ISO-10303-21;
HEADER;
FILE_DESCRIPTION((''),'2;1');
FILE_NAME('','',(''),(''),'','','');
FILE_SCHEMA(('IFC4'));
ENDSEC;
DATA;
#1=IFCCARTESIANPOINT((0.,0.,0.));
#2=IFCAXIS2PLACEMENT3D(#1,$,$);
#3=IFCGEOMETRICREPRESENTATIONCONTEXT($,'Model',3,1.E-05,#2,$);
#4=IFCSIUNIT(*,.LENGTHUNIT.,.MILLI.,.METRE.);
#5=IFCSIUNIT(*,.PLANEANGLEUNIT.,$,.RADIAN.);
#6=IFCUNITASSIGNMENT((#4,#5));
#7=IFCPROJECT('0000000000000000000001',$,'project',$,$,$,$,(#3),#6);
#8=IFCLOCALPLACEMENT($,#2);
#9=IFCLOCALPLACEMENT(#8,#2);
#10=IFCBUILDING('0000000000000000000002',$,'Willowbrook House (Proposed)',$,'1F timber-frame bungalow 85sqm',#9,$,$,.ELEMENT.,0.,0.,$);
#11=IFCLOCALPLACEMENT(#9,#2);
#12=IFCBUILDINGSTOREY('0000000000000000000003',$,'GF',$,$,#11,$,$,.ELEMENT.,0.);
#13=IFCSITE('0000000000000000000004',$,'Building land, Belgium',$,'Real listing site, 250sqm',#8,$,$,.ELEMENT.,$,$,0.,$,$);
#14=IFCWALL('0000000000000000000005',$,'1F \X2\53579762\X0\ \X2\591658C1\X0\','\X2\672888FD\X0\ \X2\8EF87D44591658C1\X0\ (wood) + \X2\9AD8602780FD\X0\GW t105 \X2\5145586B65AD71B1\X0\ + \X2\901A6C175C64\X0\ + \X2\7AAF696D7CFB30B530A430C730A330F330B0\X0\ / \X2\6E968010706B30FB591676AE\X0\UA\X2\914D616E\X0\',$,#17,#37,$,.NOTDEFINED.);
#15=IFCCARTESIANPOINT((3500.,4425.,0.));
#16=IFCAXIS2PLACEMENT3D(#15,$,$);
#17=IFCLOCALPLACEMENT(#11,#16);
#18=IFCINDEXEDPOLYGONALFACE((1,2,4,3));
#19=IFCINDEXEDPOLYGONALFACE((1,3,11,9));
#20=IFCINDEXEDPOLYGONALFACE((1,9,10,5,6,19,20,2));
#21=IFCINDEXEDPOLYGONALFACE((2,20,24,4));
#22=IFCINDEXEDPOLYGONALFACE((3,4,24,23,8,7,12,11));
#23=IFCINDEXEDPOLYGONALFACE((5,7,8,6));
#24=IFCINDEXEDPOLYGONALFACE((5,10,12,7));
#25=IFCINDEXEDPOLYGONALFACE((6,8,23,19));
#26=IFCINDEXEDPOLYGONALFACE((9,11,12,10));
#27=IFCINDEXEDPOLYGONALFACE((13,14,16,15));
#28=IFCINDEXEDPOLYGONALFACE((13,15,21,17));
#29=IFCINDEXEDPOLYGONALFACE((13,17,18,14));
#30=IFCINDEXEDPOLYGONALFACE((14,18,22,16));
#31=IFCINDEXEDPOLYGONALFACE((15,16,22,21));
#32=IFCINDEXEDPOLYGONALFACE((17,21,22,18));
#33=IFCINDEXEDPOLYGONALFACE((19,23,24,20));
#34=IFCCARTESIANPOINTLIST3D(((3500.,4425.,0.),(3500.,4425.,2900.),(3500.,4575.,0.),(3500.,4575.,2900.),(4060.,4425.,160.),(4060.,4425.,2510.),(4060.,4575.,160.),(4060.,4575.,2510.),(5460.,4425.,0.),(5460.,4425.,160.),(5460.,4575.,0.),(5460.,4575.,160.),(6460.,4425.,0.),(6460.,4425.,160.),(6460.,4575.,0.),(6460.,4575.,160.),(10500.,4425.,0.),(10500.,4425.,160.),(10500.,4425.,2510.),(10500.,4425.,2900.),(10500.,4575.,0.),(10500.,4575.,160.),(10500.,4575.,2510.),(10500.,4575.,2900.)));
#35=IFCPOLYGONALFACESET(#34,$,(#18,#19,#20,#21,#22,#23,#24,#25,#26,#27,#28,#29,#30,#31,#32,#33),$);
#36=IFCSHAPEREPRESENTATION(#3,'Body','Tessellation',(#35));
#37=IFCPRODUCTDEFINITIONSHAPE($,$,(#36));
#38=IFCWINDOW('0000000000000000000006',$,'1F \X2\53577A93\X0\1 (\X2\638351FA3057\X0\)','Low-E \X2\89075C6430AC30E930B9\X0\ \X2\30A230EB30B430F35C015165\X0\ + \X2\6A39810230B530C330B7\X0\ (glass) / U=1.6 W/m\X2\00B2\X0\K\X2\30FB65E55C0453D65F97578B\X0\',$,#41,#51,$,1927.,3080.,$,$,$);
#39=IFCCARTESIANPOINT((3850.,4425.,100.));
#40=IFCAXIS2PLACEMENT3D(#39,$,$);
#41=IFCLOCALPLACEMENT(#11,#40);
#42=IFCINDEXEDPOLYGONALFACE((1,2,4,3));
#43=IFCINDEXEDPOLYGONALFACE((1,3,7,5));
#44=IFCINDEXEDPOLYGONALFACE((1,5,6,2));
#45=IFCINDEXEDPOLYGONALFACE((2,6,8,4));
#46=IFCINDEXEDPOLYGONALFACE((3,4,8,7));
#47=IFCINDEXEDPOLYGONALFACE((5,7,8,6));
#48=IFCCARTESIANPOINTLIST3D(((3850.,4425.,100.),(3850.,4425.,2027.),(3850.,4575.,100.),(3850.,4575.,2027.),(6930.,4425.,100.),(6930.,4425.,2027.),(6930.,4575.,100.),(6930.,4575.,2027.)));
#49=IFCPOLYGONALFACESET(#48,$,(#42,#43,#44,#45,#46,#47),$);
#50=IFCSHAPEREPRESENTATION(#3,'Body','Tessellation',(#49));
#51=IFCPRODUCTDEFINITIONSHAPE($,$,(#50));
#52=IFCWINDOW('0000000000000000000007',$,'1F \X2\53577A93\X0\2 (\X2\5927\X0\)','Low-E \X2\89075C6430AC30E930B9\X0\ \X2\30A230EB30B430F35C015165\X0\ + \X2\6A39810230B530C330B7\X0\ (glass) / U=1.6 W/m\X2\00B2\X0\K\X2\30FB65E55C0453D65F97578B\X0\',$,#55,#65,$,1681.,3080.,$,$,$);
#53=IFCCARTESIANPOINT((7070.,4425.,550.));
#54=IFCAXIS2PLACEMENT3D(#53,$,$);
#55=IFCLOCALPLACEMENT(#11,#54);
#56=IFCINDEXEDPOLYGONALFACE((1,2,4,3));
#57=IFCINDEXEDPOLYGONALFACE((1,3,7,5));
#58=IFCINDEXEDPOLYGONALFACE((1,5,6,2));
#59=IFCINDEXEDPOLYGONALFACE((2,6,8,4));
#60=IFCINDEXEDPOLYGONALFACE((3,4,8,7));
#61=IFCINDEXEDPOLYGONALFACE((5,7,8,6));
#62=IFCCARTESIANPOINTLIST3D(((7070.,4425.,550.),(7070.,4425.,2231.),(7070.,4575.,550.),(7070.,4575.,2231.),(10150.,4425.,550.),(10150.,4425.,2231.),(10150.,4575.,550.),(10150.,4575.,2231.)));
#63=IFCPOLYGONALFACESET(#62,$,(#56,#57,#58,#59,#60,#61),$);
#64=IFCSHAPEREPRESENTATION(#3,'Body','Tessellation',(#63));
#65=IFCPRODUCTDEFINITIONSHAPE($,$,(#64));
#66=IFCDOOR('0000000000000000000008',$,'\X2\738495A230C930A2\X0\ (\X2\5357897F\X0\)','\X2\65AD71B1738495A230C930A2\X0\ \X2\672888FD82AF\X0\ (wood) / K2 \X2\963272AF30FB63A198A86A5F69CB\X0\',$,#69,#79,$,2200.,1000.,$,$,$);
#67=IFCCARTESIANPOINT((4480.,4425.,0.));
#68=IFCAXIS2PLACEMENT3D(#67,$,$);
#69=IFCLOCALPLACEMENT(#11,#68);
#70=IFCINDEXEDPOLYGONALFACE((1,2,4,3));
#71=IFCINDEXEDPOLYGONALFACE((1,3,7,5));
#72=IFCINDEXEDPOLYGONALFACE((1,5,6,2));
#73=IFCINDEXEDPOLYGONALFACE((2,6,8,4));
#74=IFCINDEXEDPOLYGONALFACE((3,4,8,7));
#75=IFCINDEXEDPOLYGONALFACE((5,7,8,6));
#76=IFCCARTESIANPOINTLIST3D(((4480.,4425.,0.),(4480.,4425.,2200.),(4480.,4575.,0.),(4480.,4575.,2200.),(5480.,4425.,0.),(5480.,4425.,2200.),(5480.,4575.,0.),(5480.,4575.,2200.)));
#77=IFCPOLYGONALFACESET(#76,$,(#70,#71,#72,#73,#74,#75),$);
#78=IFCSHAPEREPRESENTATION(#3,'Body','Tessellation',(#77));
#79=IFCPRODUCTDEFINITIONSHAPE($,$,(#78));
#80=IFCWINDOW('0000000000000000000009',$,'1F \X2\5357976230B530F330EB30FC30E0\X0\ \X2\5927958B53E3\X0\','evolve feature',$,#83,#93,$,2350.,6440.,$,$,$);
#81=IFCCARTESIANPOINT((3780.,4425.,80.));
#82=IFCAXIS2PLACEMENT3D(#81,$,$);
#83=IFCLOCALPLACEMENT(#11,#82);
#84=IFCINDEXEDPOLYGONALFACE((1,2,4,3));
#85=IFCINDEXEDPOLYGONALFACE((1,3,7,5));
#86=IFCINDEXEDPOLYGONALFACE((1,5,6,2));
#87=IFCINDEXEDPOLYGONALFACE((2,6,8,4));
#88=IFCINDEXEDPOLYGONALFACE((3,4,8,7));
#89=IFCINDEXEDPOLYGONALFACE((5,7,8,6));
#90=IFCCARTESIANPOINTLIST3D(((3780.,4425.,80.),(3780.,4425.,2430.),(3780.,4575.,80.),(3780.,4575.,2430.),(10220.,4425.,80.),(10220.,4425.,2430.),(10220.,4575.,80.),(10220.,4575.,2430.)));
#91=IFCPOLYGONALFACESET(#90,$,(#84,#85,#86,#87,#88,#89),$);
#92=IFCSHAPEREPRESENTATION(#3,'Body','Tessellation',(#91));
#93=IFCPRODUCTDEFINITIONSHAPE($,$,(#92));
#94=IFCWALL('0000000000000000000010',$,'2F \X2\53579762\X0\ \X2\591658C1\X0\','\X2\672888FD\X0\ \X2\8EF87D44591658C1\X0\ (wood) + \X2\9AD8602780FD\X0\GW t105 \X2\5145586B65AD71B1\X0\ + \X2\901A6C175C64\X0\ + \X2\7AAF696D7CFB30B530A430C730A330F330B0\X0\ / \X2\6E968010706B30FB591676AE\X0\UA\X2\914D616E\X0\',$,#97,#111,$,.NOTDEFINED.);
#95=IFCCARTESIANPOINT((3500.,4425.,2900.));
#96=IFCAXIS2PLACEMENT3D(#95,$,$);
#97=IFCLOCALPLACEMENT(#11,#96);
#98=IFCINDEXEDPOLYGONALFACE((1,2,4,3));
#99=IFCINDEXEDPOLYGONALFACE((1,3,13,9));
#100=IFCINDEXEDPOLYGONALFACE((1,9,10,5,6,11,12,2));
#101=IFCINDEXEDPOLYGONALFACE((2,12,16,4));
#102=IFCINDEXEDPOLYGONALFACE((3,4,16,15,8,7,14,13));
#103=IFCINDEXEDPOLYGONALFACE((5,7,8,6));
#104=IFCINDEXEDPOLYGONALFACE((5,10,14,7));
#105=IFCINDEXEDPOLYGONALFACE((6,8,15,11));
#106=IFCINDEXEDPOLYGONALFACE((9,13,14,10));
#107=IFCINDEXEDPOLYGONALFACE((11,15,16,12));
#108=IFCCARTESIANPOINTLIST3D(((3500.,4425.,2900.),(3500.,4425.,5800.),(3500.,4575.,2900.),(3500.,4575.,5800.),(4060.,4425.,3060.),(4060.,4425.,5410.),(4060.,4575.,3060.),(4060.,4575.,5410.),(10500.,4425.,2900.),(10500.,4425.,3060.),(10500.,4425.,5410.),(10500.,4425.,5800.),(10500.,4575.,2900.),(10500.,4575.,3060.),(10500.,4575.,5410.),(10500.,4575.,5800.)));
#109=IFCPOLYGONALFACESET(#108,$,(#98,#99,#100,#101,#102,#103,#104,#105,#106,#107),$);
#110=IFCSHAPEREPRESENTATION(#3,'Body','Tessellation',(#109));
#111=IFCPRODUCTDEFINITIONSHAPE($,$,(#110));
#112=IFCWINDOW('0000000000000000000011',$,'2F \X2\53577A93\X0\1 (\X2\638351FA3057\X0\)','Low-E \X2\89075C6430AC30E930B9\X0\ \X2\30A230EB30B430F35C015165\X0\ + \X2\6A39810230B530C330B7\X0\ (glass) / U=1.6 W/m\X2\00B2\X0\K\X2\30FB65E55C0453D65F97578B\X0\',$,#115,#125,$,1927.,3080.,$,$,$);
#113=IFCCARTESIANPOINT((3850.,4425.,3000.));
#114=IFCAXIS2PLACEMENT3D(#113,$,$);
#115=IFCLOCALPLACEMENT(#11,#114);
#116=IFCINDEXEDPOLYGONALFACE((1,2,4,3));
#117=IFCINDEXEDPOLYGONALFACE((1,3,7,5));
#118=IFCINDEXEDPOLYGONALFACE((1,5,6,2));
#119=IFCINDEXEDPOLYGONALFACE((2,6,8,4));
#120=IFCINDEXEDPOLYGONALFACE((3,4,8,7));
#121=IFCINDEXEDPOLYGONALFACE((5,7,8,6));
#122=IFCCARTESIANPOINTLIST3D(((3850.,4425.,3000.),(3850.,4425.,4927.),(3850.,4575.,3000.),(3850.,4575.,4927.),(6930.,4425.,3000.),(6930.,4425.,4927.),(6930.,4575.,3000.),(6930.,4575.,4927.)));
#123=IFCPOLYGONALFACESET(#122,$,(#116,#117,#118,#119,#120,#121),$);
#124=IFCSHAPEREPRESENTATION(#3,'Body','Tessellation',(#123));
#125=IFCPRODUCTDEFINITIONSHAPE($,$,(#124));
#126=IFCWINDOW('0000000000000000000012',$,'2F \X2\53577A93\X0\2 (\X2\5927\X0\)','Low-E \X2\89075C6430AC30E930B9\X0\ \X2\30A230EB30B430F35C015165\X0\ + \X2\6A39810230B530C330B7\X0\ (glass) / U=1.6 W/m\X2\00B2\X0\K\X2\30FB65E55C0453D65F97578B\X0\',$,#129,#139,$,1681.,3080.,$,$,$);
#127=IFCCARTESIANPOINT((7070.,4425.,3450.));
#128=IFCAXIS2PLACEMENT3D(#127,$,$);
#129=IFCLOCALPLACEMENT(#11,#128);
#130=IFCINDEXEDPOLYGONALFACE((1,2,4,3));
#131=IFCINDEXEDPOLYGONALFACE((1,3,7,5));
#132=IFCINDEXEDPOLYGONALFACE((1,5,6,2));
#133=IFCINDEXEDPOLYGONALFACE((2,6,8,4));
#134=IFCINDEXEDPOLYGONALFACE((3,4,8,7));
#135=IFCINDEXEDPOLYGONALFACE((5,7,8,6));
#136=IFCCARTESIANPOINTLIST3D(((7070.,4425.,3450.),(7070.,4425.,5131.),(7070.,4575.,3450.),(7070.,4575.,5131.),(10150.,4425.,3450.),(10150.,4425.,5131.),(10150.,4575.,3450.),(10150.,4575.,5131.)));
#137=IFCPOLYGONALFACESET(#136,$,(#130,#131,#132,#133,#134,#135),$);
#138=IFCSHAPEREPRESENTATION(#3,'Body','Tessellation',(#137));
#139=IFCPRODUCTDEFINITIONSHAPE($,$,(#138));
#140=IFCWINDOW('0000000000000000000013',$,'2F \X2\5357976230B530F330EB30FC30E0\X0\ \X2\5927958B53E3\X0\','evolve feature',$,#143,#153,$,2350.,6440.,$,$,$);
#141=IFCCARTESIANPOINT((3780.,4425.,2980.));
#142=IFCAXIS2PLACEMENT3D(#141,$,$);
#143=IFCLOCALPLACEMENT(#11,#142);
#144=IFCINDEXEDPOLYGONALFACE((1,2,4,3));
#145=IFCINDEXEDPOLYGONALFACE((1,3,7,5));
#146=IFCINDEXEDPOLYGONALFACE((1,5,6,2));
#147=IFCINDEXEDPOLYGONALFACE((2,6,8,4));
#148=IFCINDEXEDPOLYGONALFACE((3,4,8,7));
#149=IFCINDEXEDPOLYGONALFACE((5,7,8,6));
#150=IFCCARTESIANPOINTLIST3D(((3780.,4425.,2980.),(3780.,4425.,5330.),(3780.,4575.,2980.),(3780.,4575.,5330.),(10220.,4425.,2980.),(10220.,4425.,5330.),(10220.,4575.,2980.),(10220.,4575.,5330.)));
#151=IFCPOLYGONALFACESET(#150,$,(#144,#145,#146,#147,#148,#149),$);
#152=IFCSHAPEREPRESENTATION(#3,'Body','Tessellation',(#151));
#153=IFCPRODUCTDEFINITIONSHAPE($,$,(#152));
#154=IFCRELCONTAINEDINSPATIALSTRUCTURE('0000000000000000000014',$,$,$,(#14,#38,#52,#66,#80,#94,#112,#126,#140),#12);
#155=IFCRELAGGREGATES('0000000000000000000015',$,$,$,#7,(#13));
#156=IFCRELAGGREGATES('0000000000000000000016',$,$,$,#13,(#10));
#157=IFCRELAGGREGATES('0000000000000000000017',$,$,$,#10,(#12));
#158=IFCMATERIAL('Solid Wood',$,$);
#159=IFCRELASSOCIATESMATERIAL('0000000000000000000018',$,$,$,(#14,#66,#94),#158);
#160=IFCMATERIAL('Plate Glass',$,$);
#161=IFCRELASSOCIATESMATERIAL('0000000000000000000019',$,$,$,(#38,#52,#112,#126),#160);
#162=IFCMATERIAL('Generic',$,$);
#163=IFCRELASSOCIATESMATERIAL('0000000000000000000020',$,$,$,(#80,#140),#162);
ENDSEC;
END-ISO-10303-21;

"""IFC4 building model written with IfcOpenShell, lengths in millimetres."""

from ifc_helpers import new_model, si_unit, frame, frame_2d, origin, place, context, project, spatial, rectangle, extrude, material, element, fill, save


model = new_model("IFC4")

# Units and contexts
model_context = context("Model", 3, precision=1e-05, world=origin())
ifc_project = project(units=[si_unit("LENGTHUNIT", "METRE", prefix="MILLI"), si_unit("PLANEANGLEUNIT", "RADIAN")], contexts=[model_context])

# Site, building, storey
site_placement = place(None, origin())
site = spatial("IfcSite", under=ifc_project, at=site_placement, Name="Building land, Belgium", ObjectType="Real listing site, 250sqm", CompositionType="ELEMENT", RefElevation=0.0)
building_placement = place(site_placement, origin())
building = spatial("IfcBuilding", under=site, at=building_placement, Name="Willowbrook House (Proposed)", ObjectType="1F timber-frame bungalow 85sqm", CompositionType="ELEMENT", ElevationOfRefHeight=0.0, ElevationOfTerrain=0.0)
storey_placement = place(building_placement, origin())
storey = spatial("IfcBuildingStorey", under=building, at=storey_placement, Name="GF", CompositionType="ELEMENT", Elevation=0.0)

# Shared definitions
ifc_material_1 = material(Name="Solid Wood")
ifc_material_2 = material(Name="Generic")

# Wall, openings, windows, door
wall_1_placement = place(storey_placement, frame((3500.0, 4425.0, 0.0)))
wall_1 = element("IfcWall", 1, at=wall_1_placement, inside=storey, material=ifc_material_1, Name="1F 南面 外壁", Description="木製 軸組外壁 (wood) + 高性能GW t105 充填断熱 + 通気層 + 窯業系サイディング / 準耐火・外皮UA配慮", PredefinedType="NOTDEFINED", context=model_context, shape_type="SweptSolid", body=[
    extrude(rectangle(XDim=7000.0, YDim=150.0, at=frame_2d((3500.0, 75.0))), frame((3500.0, 4425.0, 0.0)), (0.0, 0.0, 1.0), 2900.0),
])
opening_1_placement = place(storey_placement, frame((3850.0, 4425.0, 100.0)))
opening_1 = element("IfcOpeningElement", 2, at=opening_1_placement, cuts=wall_1, PredefinedType="NOTDEFINED", context=model_context, shape_type="SweptSolid", body=[
    extrude(rectangle(XDim=3080.0, YDim=150.0, at=frame_2d((1540.0, 75.0))), frame((3850.0, 4425.0, 100.0)), (0.0, 0.0, 1.0), 1927.0),
])
opening_2_placement = place(storey_placement, frame((7070.0, 4425.0, 550.0)))
opening_2 = element("IfcOpeningElement", 3, at=opening_2_placement, cuts=wall_1, PredefinedType="NOTDEFINED", context=model_context, shape_type="SweptSolid", body=[
    extrude(rectangle(XDim=3080.0, YDim=150.0, at=frame_2d((1540.0, 75.0))), frame((7070.0, 4425.0, 550.0)), (0.0, 0.0, 1.0), 1681.0),
])
opening_3_placement = place(storey_placement, frame((4480.0, 4425.0, 0.0)))
opening_3 = element("IfcOpeningElement", 4, at=opening_3_placement, cuts=wall_1, PredefinedType="NOTDEFINED", context=model_context, shape_type="SweptSolid", body=[
    extrude(rectangle(XDim=1000.0, YDim=150.0, at=frame_2d((500.0, 75.0))), frame((4480.0, 4425.0, 0.0)), (0.0, 0.0, 1.0), 2200.0),
])
opening_4_placement = place(storey_placement, frame((3780.0, 4425.0, 80.0)))
opening_4 = element("IfcOpeningElement", 5, at=opening_4_placement, cuts=wall_1, PredefinedType="NOTDEFINED", context=model_context, shape_type="SweptSolid", body=[
    extrude(rectangle(XDim=6440.0, YDim=150.0, at=frame_2d((3220.0, 75.0))), frame((3780.0, 4425.0, 80.0)), (0.0, 0.0, 1.0), 2350.0),
])
ifc_material_3 = material(Name="Plate Glass")
window_1_placement = place(storey_placement, frame((3850.0, 4425.0, 100.0)))
window_1 = element("IfcWindow", 6, at=window_1_placement, inside=storey, material=ifc_material_3, Name="1F 南窓1 (掃出し)", Description="Low-E 複層ガラス アルゴン封入 + 樹脂サッシ (glass) / U=1.6 W/m²K・日射取得型", OverallHeight=1927.0, OverallWidth=3080.0, context=model_context, shape_type="SweptSolid", body=[
    extrude(rectangle(XDim=3080.0, YDim=150.0, at=frame_2d((1540.0, 75.0))), frame((3850.0, 4425.0, 100.0)), (0.0, 0.0, 1.0), 1927.0),
])
fill(opening_1, window_1)
window_2_placement = place(storey_placement, frame((7070.0, 4425.0, 550.0)))
window_2 = element("IfcWindow", 7, at=window_2_placement, inside=storey, material=ifc_material_3, Name="1F 南窓2 (大)", Description="Low-E 複層ガラス アルゴン封入 + 樹脂サッシ (glass) / U=1.6 W/m²K・日射取得型", OverallHeight=1681.0, OverallWidth=3080.0, context=model_context, shape_type="SweptSolid", body=[
    extrude(rectangle(XDim=3080.0, YDim=150.0, at=frame_2d((1540.0, 75.0))), frame((7070.0, 4425.0, 550.0)), (0.0, 0.0, 1.0), 1681.0),
])
fill(opening_2, window_2)
door_placement = place(storey_placement, frame((4480.0, 4425.0, 0.0)))
door = element("IfcDoor", 8, at=door_placement, inside=storey, material=ifc_material_1, Name="玄関ドア (南西)", Description="断熱玄関ドア 木製芯 (wood) / K2 防犯・採風機構", OverallHeight=2200.0, OverallWidth=1000.0, context=model_context, shape_type="SweptSolid", body=[
    extrude(rectangle(XDim=1000.0, YDim=150.0, at=frame_2d((500.0, 75.0))), frame((4480.0, 4425.0, 0.0)), (0.0, 0.0, 1.0), 2200.0),
])
fill(opening_3, door)
window_3_placement = place(storey_placement, frame((3780.0, 4425.0, 80.0)))
window_3 = element("IfcWindow", 9, at=window_3_placement, inside=storey, material=ifc_material_2, Name="1F 南面サンルーム 大開口", Description="evolve feature", OverallHeight=2350.0, OverallWidth=6440.0, context=model_context, shape_type="SweptSolid", body=[
    extrude(rectangle(XDim=6440.0, YDim=150.0, at=frame_2d((3220.0, 75.0))), frame((3780.0, 4425.0, 80.0)), (0.0, 0.0, 1.0), 2350.0),
])
fill(opening_4, window_3)

# Wall, openings, windows
wall_2_placement = place(storey_placement, frame((3500.0, 4425.0, 2900.0)))
wall_2 = element("IfcWall", 10, at=wall_2_placement, inside=storey, material=ifc_material_1, Name="2F 南面 外壁", Description="木製 軸組外壁 (wood) + 高性能GW t105 充填断熱 + 通気層 + 窯業系サイディング / 準耐火・外皮UA配慮", PredefinedType="NOTDEFINED", context=model_context, shape_type="SweptSolid", body=[
    extrude(rectangle(XDim=7000.0, YDim=150.0, at=frame_2d((3500.0, 75.0))), frame((3500.0, 4425.0, 2900.0)), (0.0, 0.0, 1.0), 2900.0),
])
opening_5_placement = place(storey_placement, frame((3850.0, 4425.0, 3000.0)))
opening_5 = element("IfcOpeningElement", 11, at=opening_5_placement, cuts=wall_2, PredefinedType="NOTDEFINED", context=model_context, shape_type="SweptSolid", body=[
    extrude(rectangle(XDim=3080.0, YDim=150.0, at=frame_2d((1540.0, 75.0))), frame((3850.0, 4425.0, 3000.0)), (0.0, 0.0, 1.0), 1927.0),
])
opening_6_placement = place(storey_placement, frame((7070.0, 4425.0, 3450.0)))
opening_6 = element("IfcOpeningElement", 12, at=opening_6_placement, cuts=wall_2, PredefinedType="NOTDEFINED", context=model_context, shape_type="SweptSolid", body=[
    extrude(rectangle(XDim=3080.0, YDim=150.0, at=frame_2d((1540.0, 75.0))), frame((7070.0, 4425.0, 3450.0)), (0.0, 0.0, 1.0), 1681.0),
])
opening_7_placement = place(storey_placement, frame((3780.0, 4425.0, 2980.0)))
opening_7 = element("IfcOpeningElement", 13, at=opening_7_placement, cuts=wall_2, PredefinedType="NOTDEFINED", context=model_context, shape_type="SweptSolid", body=[
    extrude(rectangle(XDim=6440.0, YDim=150.0, at=frame_2d((3220.0, 75.0))), frame((3780.0, 4425.0, 2980.0)), (0.0, 0.0, 1.0), 2350.0),
])
window_4_placement = place(storey_placement, frame((3850.0, 4425.0, 3000.0)))
window_4 = element("IfcWindow", 14, at=window_4_placement, inside=storey, material=ifc_material_3, Name="2F 南窓1 (掃出し)", Description="Low-E 複層ガラス アルゴン封入 + 樹脂サッシ (glass) / U=1.6 W/m²K・日射取得型", OverallHeight=1927.0, OverallWidth=3080.0, context=model_context, shape_type="SweptSolid", body=[
    extrude(rectangle(XDim=3080.0, YDim=150.0, at=frame_2d((1540.0, 75.0))), frame((3850.0, 4425.0, 3000.0)), (0.0, 0.0, 1.0), 1927.0),
])
fill(opening_5, window_4)
window_5_placement = place(storey_placement, frame((7070.0, 4425.0, 3450.0)))
window_5 = element("IfcWindow", 15, at=window_5_placement, inside=storey, material=ifc_material_3, Name="2F 南窓2 (大)", Description="Low-E 複層ガラス アルゴン封入 + 樹脂サッシ (glass) / U=1.6 W/m²K・日射取得型", OverallHeight=1681.0, OverallWidth=3080.0, context=model_context, shape_type="SweptSolid", body=[
    extrude(rectangle(XDim=3080.0, YDim=150.0, at=frame_2d((1540.0, 75.0))), frame((7070.0, 4425.0, 3450.0)), (0.0, 0.0, 1.0), 1681.0),
])
fill(opening_6, window_5)
window_6_placement = place(storey_placement, frame((3780.0, 4425.0, 2980.0)))
window_6 = element("IfcWindow", 16, at=window_6_placement, inside=storey, material=ifc_material_2, Name="2F 南面サンルーム 大開口", Description="evolve feature", OverallHeight=2350.0, OverallWidth=6440.0, context=model_context, shape_type="SweptSolid", body=[
    extrude(rectangle(XDim=6440.0, YDim=150.0, at=frame_2d((3220.0, 75.0))), frame((3780.0, 4425.0, 2980.0)), (0.0, 0.0, 1.0), 2350.0),
])
fill(opening_7, window_6)

save(model, "model.ifc")
